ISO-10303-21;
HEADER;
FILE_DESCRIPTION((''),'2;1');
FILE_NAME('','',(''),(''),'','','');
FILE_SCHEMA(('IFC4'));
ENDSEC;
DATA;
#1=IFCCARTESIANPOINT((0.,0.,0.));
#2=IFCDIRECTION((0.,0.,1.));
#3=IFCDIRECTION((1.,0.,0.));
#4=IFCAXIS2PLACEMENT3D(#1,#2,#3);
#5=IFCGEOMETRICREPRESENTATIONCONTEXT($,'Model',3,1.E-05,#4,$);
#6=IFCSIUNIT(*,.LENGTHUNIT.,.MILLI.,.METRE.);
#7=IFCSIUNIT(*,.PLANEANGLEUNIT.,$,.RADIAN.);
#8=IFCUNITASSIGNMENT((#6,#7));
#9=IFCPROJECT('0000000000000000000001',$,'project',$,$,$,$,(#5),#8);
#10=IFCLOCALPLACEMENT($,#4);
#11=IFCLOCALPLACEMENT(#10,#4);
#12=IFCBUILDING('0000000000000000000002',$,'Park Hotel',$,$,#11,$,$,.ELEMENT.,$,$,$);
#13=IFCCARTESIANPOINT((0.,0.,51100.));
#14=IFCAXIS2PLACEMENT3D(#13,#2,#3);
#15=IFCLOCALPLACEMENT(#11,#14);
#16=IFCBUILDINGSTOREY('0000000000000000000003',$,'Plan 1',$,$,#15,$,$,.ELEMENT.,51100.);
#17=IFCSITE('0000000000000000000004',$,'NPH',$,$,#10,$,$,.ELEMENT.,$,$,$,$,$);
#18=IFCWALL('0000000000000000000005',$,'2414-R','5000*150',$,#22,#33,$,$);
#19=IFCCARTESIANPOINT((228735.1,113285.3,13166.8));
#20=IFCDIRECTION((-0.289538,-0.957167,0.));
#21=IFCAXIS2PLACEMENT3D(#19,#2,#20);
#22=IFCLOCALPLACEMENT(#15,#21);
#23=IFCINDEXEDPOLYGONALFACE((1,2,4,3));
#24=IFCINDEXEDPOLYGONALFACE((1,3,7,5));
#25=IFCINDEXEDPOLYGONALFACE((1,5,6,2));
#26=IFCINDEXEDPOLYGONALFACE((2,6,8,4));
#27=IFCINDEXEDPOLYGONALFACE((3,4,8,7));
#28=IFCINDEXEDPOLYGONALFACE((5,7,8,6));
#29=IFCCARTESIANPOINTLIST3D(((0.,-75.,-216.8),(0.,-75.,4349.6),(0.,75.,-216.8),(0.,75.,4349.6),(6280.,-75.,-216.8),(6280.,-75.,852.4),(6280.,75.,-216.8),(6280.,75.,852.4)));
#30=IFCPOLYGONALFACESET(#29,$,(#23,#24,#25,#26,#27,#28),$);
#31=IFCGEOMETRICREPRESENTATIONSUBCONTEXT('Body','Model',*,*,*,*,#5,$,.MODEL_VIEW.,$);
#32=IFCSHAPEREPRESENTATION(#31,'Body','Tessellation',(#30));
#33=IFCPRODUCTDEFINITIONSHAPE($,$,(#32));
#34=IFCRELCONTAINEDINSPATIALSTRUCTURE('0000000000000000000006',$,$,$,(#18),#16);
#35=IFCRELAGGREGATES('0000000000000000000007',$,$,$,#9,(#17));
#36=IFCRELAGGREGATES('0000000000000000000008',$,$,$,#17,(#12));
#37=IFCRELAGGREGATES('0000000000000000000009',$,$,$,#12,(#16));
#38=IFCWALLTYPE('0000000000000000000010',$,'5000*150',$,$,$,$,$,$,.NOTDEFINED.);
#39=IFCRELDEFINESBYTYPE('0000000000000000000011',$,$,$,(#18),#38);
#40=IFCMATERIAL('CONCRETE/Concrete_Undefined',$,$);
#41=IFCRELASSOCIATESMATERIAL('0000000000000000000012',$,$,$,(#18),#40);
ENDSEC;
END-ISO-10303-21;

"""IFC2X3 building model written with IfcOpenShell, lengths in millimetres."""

from ifc_helpers import new_model, si_unit, frame, frame_2d, origin_with_axes, place, context, subcontext, project, spatial, rectangle, extrude, clip, halfspace, material, type_object, element, save


model = new_model("IFC2X3")

# Units and contexts
model_context = context("Model", 3, precision=1e-05, world=origin_with_axes())
body_context = subcontext(model_context, "Body", "Model", "MODEL_VIEW")
ifc_project = project(units=[si_unit("LENGTHUNIT", "METRE", prefix="MILLI"), si_unit("PLANEANGLEUNIT", "RADIAN")], contexts=[model_context])

# Site, building, storey
site_placement = place(None, origin_with_axes())
site = spatial("IfcSite", under=ifc_project, at=site_placement, Name="NPH", CompositionType="ELEMENT")
building_placement = place(site_placement, origin_with_axes())
building = spatial("IfcBuilding", under=site, at=building_placement, Name="Park Hotel", CompositionType="ELEMENT")
storey_placement = place(building_placement, frame((0.0, 0.0, 51100.0), z_axis=(0.0, 0.0, 1.0), x_axis=(1.0, 0.0, 0.0)))
storey = spatial("IfcBuildingStorey", under=building, at=storey_placement, Name="Plan 1", CompositionType="ELEMENT", Elevation=51100.0)

# Wall
ifc_material_1 = material(Name="CONCRETE/Concrete_Undefined")
wall_type_1 = type_object("IfcWallType", Name="5000*150", PredefinedType="NOTDEFINED")
wall_1_placement = place(storey_placement, frame((228735.1, 113285.3, 13166.8), z_axis=(0.0, 0.0, 1.0), x_axis=(-0.289538, -0.957167, 0.0)))
element("IfcWall", 1, at=wall_1_placement, inside=storey, type_object=wall_type_1, material=ifc_material_1, Name="2414-R", Description="5000*150", context=body_context, shape_type="Clipping", body=[
    clip(extrude(rectangle(XDim=6280.0, YDim=150.0, at=frame_2d((0.0, 3140.0), x_axis=(0.0, -1.0))), frame((0.0, 0.0, -216.8), z_axis=(0.0, 0.0, 1.0), x_axis=(0.0, -1.0, 0.0)), (0.0, 0.0, 1.0), 5000.0), halfspace(frame((8200.1, -75.0, -216.8), z_axis=(0.48652, -0.000001, 0.873669), x_axis=(-0.873669, 0.0, 0.48652)), False)),
])

save(model, "model.ifc")
